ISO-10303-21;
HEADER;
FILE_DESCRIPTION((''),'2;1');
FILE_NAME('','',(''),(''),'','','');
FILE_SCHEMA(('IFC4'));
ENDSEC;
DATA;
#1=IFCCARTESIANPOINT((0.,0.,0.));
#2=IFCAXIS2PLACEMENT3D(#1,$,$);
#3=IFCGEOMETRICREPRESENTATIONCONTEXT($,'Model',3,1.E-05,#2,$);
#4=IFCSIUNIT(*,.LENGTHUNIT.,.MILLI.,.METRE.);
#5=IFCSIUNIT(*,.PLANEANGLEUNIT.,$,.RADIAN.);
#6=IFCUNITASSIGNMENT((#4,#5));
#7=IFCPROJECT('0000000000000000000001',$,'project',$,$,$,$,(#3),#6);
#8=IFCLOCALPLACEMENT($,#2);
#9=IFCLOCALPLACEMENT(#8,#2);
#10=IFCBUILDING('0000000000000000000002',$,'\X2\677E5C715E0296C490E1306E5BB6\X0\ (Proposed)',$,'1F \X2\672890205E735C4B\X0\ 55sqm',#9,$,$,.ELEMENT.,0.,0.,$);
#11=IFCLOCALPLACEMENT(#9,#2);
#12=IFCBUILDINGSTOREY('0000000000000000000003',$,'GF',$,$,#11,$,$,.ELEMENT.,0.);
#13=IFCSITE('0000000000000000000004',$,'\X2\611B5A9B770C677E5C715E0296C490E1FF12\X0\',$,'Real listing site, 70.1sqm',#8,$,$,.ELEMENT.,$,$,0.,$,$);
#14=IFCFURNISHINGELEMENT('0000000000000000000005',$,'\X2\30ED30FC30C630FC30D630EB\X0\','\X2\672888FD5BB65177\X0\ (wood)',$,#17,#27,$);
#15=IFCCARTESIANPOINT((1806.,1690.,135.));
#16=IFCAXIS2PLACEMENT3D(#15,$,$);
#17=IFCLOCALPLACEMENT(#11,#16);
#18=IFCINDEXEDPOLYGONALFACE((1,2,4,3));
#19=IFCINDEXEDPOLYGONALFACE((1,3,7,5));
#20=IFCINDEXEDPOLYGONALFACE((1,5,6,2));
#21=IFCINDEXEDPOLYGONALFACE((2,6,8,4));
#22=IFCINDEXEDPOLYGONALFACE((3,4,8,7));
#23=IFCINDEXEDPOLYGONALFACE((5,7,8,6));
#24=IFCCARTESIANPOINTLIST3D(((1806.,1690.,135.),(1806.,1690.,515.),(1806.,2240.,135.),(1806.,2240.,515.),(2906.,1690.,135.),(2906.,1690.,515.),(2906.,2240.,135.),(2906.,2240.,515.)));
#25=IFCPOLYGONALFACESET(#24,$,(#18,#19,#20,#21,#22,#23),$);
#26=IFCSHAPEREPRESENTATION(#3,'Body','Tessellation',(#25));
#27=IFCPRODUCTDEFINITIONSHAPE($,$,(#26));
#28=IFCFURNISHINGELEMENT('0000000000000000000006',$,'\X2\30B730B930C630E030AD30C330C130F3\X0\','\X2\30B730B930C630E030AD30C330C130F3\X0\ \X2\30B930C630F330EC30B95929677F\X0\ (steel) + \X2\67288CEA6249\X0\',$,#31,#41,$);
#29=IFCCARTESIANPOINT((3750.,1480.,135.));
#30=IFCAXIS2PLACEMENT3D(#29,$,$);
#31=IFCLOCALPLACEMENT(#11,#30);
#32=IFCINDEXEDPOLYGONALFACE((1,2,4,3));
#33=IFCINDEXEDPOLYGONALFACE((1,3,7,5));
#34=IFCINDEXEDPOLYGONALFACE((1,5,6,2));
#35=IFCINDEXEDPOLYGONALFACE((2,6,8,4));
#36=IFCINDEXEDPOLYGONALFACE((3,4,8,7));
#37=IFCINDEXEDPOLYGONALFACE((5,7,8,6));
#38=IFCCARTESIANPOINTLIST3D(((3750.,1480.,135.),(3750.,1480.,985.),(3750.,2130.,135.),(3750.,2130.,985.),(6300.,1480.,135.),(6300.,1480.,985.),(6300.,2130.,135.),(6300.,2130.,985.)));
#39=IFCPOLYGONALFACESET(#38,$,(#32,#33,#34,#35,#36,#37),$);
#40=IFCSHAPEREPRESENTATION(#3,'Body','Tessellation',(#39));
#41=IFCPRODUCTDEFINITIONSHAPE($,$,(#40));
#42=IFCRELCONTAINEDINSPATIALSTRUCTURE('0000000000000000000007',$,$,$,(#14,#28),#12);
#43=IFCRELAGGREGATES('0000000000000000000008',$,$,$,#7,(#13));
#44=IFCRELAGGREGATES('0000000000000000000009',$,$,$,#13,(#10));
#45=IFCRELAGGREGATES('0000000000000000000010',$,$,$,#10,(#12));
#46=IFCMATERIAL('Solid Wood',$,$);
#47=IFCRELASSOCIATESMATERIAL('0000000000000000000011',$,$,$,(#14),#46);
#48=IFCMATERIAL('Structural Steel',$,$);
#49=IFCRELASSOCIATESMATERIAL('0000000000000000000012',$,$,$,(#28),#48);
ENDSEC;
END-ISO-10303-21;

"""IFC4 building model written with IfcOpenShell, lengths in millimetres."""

from ifc_helpers import new_model, si_unit, frame, frame_2d, origin, place, context, project, spatial, rectangle, extrude, material, element, save


model = new_model("IFC4")

# Units and contexts
model_context = context("Model", 3, precision=1e-05, world=origin())
ifc_project = project(units=[si_unit("LENGTHUNIT", "METRE", prefix="MILLI"), si_unit("PLANEANGLEUNIT", "RADIAN")], contexts=[model_context])

# Site, building, storey
site_placement = place(None, origin())
site = spatial("IfcSite", under=ifc_project, at=site_placement, Name="愛媛県松山市雄郡２", ObjectType="Real listing site, 70.1sqm", CompositionType="ELEMENT", RefElevation=0.0)
building_placement = place(site_placement, origin())
building = spatial("IfcBuilding", under=site, at=building_placement, Name="松山市雄郡の家 (Proposed)", ObjectType="1F 木造平屋 55sqm", CompositionType="ELEMENT", ElevationOfRefHeight=0.0, ElevationOfTerrain=0.0)
storey_placement = place(building_placement, origin())
storey = spatial("IfcBuildingStorey", under=building, at=storey_placement, Name="GF", CompositionType="ELEMENT", Elevation=0.0)

# Shared definitions
ifc_material_1 = material(Name="Solid Wood")

# Furnishing elements
furnishing_1_placement = place(storey_placement, frame((1806.0, 1690.0, 135.0)))
element("IfcFurnishingElement", 1, at=furnishing_1_placement, inside=storey, material=ifc_material_1, Name="ローテーブル", Description="木製家具 (wood)", context=model_context, shape_type="SweptSolid", body=[
    extrude(rectangle(XDim=1100.0, YDim=550.0, at=frame_2d((550.0, 275.0))), frame((1806.0, 1690.0, 135.0)), (0.0, 0.0, 1.0), 380.0),
])
ifc_material_2 = material(Name="Structural Steel")
furnishing_2_placement = place(storey_placement, frame((3750.0, 1480.0, 135.0)))
element("IfcFurnishingElement", 2, at=furnishing_2_placement, inside=storey, material=ifc_material_2, Name="システムキッチン", Description="システムキッチン ステンレス天板 (steel) + 木質扉", context=model_context, shape_type="SweptSolid", body=[
    extrude(rectangle(XDim=2550.0, YDim=650.0, at=frame_2d((1275.0, 325.0))), frame((3750.0, 1480.0, 135.0)), (0.0, 0.0, 1.0), 850.0),
])

save(model, "model.ifc")
